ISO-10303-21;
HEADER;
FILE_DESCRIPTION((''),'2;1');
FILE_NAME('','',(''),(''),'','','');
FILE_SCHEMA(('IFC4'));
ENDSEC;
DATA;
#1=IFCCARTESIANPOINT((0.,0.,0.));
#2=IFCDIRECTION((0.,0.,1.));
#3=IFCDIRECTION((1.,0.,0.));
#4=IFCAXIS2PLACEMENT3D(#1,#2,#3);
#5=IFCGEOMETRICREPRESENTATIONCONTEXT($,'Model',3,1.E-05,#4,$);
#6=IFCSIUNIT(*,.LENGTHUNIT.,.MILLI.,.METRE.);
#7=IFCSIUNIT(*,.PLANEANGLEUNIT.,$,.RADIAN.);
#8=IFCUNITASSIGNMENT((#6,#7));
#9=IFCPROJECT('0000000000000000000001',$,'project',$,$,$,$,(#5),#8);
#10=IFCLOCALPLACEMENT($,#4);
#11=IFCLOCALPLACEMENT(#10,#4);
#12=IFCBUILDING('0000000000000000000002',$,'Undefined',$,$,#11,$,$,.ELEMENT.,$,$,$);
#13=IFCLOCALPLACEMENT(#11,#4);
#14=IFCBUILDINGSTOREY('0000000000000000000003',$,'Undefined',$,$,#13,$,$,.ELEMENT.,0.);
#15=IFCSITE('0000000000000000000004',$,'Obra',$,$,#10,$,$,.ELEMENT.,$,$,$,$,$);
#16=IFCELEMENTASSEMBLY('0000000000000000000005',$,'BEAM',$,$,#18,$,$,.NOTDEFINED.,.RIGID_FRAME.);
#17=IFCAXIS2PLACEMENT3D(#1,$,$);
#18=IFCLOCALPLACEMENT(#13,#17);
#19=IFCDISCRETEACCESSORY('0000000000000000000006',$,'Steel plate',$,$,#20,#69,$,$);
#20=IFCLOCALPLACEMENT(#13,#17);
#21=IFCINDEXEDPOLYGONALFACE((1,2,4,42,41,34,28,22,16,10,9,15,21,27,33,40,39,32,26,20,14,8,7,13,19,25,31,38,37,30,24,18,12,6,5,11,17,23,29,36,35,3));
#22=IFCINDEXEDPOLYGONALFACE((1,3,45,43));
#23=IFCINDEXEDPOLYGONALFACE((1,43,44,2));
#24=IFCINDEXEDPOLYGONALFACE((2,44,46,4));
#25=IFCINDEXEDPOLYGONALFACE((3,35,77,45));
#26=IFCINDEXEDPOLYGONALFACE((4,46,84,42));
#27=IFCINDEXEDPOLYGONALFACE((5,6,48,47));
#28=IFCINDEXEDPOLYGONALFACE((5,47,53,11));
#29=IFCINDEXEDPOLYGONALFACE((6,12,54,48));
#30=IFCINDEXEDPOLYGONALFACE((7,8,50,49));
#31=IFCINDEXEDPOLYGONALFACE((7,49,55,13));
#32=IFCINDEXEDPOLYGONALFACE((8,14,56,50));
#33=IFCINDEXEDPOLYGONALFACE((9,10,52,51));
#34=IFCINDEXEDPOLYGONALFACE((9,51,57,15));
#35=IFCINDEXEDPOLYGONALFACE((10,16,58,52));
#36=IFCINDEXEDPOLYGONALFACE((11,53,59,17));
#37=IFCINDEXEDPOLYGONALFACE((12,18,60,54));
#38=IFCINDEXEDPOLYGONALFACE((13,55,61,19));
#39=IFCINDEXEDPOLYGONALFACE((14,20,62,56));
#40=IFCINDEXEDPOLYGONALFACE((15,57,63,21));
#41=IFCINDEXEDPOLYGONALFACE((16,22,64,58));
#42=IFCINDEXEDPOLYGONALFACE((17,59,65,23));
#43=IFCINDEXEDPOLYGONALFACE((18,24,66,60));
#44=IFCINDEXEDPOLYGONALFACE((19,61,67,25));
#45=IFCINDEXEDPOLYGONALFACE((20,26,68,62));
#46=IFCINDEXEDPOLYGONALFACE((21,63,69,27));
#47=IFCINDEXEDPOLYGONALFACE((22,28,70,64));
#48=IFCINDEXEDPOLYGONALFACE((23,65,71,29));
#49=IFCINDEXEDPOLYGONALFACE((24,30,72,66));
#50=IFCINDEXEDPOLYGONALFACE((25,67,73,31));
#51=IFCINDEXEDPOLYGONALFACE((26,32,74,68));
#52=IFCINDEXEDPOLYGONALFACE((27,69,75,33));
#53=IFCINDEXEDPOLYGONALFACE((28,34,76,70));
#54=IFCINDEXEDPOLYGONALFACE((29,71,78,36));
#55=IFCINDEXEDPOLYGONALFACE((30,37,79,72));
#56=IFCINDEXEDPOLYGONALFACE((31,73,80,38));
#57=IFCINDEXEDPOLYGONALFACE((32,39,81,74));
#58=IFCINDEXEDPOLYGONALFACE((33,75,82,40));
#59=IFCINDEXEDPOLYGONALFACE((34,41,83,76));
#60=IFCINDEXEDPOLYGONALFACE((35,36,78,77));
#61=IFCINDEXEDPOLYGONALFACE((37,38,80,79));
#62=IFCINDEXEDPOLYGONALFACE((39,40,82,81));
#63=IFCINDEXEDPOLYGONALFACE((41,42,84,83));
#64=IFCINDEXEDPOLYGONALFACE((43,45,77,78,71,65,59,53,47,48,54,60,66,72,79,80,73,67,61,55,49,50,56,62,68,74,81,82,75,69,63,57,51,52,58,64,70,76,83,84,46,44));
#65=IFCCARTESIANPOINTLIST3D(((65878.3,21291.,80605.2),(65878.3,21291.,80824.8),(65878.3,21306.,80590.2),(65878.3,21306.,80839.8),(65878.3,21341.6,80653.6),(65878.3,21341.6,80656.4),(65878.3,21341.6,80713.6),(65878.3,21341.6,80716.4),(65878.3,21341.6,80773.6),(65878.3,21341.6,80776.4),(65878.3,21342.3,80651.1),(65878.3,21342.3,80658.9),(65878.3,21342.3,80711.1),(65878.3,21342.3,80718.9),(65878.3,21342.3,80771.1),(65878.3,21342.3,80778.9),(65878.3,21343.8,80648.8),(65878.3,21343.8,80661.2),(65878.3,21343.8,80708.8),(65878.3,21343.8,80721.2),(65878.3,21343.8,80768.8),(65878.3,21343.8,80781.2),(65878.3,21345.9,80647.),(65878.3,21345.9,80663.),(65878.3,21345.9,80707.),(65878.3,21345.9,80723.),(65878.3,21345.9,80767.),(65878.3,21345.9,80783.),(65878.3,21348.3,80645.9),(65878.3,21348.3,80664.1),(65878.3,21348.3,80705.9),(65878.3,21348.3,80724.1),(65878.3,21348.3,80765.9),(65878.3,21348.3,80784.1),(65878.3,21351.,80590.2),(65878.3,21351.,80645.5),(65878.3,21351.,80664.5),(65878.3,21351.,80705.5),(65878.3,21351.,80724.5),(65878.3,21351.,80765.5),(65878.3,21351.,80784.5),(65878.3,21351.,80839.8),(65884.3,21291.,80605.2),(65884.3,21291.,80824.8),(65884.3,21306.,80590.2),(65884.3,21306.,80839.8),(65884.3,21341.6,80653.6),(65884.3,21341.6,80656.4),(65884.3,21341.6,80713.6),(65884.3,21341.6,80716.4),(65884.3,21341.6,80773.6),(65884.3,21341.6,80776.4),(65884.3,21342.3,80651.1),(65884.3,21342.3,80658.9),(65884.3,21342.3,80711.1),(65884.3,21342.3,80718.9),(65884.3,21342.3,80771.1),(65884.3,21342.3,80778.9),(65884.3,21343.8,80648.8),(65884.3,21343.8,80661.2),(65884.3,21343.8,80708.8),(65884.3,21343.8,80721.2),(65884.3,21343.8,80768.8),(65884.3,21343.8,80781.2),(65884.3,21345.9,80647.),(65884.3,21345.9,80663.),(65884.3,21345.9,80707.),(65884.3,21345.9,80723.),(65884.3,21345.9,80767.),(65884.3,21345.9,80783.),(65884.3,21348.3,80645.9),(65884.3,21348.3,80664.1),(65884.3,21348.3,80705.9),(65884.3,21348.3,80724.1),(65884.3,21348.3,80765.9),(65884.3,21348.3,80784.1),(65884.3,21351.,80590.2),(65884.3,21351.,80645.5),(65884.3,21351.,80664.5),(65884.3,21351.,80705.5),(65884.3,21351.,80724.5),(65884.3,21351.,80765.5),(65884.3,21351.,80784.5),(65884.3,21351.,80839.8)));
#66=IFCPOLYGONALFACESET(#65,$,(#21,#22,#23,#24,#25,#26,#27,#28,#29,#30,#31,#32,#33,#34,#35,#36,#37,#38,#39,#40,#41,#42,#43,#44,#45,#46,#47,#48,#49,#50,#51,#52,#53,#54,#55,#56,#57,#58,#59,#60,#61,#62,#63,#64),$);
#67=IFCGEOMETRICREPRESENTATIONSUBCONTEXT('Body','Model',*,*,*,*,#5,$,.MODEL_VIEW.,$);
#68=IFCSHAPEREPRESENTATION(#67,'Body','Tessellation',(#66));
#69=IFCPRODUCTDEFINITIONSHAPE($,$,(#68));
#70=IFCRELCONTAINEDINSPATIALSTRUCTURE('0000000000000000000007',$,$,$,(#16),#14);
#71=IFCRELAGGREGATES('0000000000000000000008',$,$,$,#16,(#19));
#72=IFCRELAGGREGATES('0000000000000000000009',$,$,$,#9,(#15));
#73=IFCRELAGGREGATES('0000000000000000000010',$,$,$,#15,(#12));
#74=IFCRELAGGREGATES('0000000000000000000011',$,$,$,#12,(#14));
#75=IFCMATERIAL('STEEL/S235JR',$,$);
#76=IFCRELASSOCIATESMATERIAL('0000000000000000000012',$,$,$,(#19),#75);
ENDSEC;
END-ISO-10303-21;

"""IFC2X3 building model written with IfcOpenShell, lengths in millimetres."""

from ifc_helpers import new_model, si_unit, frame, origin_with_axes, origin_2d_with_axis, place, context, subcontext, project, spatial, polyline, circle, outline, extrude, source, transform, mapped, material, element, aggregate, save


model = new_model("IFC2X3")

# Units and contexts
model_context = context("Model", 3, precision=1e-05, world=origin_with_axes())
body_context = subcontext(model_context, "Body", "Model", "MODEL_VIEW")
ifc_project = project(units=[si_unit("LENGTHUNIT", "METRE", prefix="MILLI"), si_unit("PLANEANGLEUNIT", "RADIAN")], contexts=[model_context])

# Site, building, storey
site_placement = place(None, origin_with_axes())
site = spatial("IfcSite", under=ifc_project, at=site_placement, Name="Obra", CompositionType="ELEMENT")
building_placement = place(site_placement, origin_with_axes())
building = spatial("IfcBuilding", under=site, at=building_placement, Name="Undefined", CompositionType="ELEMENT")
storey_placement = place(building_placement, origin_with_axes())
storey = spatial("IfcBuildingStorey", under=building, at=storey_placement, Name="Undefined", CompositionType="ELEMENT", Elevation=0.0)

# Shared definitions
ifc_material = material(Name="STEEL/S235JR")

# Element assembly, discrete accessory, opening
assembly_1_placement = place(storey_placement, origin_with_axes())
assembly_1 = element("IfcElementAssembly", 1, at=assembly_1_placement, inside=storey, Name="BEAM", AssemblyPlace="NOTDEFINED", PredefinedType="RIGID_FRAME")
discrete_accessory_1_placement = place(assembly_1_placement, frame((65881.3, 21351.0, 80590.2), z_axis=(-1.0, -0.000001, 0.0), x_axis=(0.000001, -1.0, 0.0)))
discrete_accessory_1 = element("IfcDiscreteAccessory", 2, at=discrete_accessory_1_placement, material=ifc_material, Name="Steel plate", context=body_context, shape_type="SweptSolid", body=[
    extrude(outline(polyline([(0.0, 0.0), (45.0, 0.0), (60.0, 15.0), (60.0, 234.6), (45.0, 249.6), (0.0, 249.6), (0.0, 0.0)])), frame((0.0, 0.0, -3.0), z_axis=(0.0, 0.0, 1.0), x_axis=(1.0, 0.0, 0.0)), (0.0, 0.0, 1.0), 6.0),
])
shared_shape_1 = source(origin_with_axes(), body_context, "Body", "SweptSolid", [
    extrude(circle(Radius=9.5, at=origin_2d_with_axis()), frame((0.0, -9.4, 0.0), z_axis=(0.0, 1.0, 0.0), x_axis=(1.0, 0.0, 0.0)), (0.0, 0.0, 1.0), 6.2),
])
opening_1_placement = place(assembly_1_placement, frame((65875.0, 21301.0, 80850.0), z_axis=(-0.000001, 1.0, 0.0), x_axis=(0.0, 0.0, -1.0)))
element("IfcOpeningElement", 3, at=opening_1_placement, cuts=discrete_accessory_1, ObjectType="Opening", context=body_context, shape_type="MappedRepresentation", body=[
    mapped(shared_shape_1, transform((75.0, 0.0, 50.0))),
    mapped(shared_shape_1, transform((135.0, 0.0, 50.0))),
    mapped(shared_shape_1, transform((195.0, 0.0, 50.0))),
])
aggregate(assembly_1, [discrete_accessory_1])

save(model, "model.ifc")
